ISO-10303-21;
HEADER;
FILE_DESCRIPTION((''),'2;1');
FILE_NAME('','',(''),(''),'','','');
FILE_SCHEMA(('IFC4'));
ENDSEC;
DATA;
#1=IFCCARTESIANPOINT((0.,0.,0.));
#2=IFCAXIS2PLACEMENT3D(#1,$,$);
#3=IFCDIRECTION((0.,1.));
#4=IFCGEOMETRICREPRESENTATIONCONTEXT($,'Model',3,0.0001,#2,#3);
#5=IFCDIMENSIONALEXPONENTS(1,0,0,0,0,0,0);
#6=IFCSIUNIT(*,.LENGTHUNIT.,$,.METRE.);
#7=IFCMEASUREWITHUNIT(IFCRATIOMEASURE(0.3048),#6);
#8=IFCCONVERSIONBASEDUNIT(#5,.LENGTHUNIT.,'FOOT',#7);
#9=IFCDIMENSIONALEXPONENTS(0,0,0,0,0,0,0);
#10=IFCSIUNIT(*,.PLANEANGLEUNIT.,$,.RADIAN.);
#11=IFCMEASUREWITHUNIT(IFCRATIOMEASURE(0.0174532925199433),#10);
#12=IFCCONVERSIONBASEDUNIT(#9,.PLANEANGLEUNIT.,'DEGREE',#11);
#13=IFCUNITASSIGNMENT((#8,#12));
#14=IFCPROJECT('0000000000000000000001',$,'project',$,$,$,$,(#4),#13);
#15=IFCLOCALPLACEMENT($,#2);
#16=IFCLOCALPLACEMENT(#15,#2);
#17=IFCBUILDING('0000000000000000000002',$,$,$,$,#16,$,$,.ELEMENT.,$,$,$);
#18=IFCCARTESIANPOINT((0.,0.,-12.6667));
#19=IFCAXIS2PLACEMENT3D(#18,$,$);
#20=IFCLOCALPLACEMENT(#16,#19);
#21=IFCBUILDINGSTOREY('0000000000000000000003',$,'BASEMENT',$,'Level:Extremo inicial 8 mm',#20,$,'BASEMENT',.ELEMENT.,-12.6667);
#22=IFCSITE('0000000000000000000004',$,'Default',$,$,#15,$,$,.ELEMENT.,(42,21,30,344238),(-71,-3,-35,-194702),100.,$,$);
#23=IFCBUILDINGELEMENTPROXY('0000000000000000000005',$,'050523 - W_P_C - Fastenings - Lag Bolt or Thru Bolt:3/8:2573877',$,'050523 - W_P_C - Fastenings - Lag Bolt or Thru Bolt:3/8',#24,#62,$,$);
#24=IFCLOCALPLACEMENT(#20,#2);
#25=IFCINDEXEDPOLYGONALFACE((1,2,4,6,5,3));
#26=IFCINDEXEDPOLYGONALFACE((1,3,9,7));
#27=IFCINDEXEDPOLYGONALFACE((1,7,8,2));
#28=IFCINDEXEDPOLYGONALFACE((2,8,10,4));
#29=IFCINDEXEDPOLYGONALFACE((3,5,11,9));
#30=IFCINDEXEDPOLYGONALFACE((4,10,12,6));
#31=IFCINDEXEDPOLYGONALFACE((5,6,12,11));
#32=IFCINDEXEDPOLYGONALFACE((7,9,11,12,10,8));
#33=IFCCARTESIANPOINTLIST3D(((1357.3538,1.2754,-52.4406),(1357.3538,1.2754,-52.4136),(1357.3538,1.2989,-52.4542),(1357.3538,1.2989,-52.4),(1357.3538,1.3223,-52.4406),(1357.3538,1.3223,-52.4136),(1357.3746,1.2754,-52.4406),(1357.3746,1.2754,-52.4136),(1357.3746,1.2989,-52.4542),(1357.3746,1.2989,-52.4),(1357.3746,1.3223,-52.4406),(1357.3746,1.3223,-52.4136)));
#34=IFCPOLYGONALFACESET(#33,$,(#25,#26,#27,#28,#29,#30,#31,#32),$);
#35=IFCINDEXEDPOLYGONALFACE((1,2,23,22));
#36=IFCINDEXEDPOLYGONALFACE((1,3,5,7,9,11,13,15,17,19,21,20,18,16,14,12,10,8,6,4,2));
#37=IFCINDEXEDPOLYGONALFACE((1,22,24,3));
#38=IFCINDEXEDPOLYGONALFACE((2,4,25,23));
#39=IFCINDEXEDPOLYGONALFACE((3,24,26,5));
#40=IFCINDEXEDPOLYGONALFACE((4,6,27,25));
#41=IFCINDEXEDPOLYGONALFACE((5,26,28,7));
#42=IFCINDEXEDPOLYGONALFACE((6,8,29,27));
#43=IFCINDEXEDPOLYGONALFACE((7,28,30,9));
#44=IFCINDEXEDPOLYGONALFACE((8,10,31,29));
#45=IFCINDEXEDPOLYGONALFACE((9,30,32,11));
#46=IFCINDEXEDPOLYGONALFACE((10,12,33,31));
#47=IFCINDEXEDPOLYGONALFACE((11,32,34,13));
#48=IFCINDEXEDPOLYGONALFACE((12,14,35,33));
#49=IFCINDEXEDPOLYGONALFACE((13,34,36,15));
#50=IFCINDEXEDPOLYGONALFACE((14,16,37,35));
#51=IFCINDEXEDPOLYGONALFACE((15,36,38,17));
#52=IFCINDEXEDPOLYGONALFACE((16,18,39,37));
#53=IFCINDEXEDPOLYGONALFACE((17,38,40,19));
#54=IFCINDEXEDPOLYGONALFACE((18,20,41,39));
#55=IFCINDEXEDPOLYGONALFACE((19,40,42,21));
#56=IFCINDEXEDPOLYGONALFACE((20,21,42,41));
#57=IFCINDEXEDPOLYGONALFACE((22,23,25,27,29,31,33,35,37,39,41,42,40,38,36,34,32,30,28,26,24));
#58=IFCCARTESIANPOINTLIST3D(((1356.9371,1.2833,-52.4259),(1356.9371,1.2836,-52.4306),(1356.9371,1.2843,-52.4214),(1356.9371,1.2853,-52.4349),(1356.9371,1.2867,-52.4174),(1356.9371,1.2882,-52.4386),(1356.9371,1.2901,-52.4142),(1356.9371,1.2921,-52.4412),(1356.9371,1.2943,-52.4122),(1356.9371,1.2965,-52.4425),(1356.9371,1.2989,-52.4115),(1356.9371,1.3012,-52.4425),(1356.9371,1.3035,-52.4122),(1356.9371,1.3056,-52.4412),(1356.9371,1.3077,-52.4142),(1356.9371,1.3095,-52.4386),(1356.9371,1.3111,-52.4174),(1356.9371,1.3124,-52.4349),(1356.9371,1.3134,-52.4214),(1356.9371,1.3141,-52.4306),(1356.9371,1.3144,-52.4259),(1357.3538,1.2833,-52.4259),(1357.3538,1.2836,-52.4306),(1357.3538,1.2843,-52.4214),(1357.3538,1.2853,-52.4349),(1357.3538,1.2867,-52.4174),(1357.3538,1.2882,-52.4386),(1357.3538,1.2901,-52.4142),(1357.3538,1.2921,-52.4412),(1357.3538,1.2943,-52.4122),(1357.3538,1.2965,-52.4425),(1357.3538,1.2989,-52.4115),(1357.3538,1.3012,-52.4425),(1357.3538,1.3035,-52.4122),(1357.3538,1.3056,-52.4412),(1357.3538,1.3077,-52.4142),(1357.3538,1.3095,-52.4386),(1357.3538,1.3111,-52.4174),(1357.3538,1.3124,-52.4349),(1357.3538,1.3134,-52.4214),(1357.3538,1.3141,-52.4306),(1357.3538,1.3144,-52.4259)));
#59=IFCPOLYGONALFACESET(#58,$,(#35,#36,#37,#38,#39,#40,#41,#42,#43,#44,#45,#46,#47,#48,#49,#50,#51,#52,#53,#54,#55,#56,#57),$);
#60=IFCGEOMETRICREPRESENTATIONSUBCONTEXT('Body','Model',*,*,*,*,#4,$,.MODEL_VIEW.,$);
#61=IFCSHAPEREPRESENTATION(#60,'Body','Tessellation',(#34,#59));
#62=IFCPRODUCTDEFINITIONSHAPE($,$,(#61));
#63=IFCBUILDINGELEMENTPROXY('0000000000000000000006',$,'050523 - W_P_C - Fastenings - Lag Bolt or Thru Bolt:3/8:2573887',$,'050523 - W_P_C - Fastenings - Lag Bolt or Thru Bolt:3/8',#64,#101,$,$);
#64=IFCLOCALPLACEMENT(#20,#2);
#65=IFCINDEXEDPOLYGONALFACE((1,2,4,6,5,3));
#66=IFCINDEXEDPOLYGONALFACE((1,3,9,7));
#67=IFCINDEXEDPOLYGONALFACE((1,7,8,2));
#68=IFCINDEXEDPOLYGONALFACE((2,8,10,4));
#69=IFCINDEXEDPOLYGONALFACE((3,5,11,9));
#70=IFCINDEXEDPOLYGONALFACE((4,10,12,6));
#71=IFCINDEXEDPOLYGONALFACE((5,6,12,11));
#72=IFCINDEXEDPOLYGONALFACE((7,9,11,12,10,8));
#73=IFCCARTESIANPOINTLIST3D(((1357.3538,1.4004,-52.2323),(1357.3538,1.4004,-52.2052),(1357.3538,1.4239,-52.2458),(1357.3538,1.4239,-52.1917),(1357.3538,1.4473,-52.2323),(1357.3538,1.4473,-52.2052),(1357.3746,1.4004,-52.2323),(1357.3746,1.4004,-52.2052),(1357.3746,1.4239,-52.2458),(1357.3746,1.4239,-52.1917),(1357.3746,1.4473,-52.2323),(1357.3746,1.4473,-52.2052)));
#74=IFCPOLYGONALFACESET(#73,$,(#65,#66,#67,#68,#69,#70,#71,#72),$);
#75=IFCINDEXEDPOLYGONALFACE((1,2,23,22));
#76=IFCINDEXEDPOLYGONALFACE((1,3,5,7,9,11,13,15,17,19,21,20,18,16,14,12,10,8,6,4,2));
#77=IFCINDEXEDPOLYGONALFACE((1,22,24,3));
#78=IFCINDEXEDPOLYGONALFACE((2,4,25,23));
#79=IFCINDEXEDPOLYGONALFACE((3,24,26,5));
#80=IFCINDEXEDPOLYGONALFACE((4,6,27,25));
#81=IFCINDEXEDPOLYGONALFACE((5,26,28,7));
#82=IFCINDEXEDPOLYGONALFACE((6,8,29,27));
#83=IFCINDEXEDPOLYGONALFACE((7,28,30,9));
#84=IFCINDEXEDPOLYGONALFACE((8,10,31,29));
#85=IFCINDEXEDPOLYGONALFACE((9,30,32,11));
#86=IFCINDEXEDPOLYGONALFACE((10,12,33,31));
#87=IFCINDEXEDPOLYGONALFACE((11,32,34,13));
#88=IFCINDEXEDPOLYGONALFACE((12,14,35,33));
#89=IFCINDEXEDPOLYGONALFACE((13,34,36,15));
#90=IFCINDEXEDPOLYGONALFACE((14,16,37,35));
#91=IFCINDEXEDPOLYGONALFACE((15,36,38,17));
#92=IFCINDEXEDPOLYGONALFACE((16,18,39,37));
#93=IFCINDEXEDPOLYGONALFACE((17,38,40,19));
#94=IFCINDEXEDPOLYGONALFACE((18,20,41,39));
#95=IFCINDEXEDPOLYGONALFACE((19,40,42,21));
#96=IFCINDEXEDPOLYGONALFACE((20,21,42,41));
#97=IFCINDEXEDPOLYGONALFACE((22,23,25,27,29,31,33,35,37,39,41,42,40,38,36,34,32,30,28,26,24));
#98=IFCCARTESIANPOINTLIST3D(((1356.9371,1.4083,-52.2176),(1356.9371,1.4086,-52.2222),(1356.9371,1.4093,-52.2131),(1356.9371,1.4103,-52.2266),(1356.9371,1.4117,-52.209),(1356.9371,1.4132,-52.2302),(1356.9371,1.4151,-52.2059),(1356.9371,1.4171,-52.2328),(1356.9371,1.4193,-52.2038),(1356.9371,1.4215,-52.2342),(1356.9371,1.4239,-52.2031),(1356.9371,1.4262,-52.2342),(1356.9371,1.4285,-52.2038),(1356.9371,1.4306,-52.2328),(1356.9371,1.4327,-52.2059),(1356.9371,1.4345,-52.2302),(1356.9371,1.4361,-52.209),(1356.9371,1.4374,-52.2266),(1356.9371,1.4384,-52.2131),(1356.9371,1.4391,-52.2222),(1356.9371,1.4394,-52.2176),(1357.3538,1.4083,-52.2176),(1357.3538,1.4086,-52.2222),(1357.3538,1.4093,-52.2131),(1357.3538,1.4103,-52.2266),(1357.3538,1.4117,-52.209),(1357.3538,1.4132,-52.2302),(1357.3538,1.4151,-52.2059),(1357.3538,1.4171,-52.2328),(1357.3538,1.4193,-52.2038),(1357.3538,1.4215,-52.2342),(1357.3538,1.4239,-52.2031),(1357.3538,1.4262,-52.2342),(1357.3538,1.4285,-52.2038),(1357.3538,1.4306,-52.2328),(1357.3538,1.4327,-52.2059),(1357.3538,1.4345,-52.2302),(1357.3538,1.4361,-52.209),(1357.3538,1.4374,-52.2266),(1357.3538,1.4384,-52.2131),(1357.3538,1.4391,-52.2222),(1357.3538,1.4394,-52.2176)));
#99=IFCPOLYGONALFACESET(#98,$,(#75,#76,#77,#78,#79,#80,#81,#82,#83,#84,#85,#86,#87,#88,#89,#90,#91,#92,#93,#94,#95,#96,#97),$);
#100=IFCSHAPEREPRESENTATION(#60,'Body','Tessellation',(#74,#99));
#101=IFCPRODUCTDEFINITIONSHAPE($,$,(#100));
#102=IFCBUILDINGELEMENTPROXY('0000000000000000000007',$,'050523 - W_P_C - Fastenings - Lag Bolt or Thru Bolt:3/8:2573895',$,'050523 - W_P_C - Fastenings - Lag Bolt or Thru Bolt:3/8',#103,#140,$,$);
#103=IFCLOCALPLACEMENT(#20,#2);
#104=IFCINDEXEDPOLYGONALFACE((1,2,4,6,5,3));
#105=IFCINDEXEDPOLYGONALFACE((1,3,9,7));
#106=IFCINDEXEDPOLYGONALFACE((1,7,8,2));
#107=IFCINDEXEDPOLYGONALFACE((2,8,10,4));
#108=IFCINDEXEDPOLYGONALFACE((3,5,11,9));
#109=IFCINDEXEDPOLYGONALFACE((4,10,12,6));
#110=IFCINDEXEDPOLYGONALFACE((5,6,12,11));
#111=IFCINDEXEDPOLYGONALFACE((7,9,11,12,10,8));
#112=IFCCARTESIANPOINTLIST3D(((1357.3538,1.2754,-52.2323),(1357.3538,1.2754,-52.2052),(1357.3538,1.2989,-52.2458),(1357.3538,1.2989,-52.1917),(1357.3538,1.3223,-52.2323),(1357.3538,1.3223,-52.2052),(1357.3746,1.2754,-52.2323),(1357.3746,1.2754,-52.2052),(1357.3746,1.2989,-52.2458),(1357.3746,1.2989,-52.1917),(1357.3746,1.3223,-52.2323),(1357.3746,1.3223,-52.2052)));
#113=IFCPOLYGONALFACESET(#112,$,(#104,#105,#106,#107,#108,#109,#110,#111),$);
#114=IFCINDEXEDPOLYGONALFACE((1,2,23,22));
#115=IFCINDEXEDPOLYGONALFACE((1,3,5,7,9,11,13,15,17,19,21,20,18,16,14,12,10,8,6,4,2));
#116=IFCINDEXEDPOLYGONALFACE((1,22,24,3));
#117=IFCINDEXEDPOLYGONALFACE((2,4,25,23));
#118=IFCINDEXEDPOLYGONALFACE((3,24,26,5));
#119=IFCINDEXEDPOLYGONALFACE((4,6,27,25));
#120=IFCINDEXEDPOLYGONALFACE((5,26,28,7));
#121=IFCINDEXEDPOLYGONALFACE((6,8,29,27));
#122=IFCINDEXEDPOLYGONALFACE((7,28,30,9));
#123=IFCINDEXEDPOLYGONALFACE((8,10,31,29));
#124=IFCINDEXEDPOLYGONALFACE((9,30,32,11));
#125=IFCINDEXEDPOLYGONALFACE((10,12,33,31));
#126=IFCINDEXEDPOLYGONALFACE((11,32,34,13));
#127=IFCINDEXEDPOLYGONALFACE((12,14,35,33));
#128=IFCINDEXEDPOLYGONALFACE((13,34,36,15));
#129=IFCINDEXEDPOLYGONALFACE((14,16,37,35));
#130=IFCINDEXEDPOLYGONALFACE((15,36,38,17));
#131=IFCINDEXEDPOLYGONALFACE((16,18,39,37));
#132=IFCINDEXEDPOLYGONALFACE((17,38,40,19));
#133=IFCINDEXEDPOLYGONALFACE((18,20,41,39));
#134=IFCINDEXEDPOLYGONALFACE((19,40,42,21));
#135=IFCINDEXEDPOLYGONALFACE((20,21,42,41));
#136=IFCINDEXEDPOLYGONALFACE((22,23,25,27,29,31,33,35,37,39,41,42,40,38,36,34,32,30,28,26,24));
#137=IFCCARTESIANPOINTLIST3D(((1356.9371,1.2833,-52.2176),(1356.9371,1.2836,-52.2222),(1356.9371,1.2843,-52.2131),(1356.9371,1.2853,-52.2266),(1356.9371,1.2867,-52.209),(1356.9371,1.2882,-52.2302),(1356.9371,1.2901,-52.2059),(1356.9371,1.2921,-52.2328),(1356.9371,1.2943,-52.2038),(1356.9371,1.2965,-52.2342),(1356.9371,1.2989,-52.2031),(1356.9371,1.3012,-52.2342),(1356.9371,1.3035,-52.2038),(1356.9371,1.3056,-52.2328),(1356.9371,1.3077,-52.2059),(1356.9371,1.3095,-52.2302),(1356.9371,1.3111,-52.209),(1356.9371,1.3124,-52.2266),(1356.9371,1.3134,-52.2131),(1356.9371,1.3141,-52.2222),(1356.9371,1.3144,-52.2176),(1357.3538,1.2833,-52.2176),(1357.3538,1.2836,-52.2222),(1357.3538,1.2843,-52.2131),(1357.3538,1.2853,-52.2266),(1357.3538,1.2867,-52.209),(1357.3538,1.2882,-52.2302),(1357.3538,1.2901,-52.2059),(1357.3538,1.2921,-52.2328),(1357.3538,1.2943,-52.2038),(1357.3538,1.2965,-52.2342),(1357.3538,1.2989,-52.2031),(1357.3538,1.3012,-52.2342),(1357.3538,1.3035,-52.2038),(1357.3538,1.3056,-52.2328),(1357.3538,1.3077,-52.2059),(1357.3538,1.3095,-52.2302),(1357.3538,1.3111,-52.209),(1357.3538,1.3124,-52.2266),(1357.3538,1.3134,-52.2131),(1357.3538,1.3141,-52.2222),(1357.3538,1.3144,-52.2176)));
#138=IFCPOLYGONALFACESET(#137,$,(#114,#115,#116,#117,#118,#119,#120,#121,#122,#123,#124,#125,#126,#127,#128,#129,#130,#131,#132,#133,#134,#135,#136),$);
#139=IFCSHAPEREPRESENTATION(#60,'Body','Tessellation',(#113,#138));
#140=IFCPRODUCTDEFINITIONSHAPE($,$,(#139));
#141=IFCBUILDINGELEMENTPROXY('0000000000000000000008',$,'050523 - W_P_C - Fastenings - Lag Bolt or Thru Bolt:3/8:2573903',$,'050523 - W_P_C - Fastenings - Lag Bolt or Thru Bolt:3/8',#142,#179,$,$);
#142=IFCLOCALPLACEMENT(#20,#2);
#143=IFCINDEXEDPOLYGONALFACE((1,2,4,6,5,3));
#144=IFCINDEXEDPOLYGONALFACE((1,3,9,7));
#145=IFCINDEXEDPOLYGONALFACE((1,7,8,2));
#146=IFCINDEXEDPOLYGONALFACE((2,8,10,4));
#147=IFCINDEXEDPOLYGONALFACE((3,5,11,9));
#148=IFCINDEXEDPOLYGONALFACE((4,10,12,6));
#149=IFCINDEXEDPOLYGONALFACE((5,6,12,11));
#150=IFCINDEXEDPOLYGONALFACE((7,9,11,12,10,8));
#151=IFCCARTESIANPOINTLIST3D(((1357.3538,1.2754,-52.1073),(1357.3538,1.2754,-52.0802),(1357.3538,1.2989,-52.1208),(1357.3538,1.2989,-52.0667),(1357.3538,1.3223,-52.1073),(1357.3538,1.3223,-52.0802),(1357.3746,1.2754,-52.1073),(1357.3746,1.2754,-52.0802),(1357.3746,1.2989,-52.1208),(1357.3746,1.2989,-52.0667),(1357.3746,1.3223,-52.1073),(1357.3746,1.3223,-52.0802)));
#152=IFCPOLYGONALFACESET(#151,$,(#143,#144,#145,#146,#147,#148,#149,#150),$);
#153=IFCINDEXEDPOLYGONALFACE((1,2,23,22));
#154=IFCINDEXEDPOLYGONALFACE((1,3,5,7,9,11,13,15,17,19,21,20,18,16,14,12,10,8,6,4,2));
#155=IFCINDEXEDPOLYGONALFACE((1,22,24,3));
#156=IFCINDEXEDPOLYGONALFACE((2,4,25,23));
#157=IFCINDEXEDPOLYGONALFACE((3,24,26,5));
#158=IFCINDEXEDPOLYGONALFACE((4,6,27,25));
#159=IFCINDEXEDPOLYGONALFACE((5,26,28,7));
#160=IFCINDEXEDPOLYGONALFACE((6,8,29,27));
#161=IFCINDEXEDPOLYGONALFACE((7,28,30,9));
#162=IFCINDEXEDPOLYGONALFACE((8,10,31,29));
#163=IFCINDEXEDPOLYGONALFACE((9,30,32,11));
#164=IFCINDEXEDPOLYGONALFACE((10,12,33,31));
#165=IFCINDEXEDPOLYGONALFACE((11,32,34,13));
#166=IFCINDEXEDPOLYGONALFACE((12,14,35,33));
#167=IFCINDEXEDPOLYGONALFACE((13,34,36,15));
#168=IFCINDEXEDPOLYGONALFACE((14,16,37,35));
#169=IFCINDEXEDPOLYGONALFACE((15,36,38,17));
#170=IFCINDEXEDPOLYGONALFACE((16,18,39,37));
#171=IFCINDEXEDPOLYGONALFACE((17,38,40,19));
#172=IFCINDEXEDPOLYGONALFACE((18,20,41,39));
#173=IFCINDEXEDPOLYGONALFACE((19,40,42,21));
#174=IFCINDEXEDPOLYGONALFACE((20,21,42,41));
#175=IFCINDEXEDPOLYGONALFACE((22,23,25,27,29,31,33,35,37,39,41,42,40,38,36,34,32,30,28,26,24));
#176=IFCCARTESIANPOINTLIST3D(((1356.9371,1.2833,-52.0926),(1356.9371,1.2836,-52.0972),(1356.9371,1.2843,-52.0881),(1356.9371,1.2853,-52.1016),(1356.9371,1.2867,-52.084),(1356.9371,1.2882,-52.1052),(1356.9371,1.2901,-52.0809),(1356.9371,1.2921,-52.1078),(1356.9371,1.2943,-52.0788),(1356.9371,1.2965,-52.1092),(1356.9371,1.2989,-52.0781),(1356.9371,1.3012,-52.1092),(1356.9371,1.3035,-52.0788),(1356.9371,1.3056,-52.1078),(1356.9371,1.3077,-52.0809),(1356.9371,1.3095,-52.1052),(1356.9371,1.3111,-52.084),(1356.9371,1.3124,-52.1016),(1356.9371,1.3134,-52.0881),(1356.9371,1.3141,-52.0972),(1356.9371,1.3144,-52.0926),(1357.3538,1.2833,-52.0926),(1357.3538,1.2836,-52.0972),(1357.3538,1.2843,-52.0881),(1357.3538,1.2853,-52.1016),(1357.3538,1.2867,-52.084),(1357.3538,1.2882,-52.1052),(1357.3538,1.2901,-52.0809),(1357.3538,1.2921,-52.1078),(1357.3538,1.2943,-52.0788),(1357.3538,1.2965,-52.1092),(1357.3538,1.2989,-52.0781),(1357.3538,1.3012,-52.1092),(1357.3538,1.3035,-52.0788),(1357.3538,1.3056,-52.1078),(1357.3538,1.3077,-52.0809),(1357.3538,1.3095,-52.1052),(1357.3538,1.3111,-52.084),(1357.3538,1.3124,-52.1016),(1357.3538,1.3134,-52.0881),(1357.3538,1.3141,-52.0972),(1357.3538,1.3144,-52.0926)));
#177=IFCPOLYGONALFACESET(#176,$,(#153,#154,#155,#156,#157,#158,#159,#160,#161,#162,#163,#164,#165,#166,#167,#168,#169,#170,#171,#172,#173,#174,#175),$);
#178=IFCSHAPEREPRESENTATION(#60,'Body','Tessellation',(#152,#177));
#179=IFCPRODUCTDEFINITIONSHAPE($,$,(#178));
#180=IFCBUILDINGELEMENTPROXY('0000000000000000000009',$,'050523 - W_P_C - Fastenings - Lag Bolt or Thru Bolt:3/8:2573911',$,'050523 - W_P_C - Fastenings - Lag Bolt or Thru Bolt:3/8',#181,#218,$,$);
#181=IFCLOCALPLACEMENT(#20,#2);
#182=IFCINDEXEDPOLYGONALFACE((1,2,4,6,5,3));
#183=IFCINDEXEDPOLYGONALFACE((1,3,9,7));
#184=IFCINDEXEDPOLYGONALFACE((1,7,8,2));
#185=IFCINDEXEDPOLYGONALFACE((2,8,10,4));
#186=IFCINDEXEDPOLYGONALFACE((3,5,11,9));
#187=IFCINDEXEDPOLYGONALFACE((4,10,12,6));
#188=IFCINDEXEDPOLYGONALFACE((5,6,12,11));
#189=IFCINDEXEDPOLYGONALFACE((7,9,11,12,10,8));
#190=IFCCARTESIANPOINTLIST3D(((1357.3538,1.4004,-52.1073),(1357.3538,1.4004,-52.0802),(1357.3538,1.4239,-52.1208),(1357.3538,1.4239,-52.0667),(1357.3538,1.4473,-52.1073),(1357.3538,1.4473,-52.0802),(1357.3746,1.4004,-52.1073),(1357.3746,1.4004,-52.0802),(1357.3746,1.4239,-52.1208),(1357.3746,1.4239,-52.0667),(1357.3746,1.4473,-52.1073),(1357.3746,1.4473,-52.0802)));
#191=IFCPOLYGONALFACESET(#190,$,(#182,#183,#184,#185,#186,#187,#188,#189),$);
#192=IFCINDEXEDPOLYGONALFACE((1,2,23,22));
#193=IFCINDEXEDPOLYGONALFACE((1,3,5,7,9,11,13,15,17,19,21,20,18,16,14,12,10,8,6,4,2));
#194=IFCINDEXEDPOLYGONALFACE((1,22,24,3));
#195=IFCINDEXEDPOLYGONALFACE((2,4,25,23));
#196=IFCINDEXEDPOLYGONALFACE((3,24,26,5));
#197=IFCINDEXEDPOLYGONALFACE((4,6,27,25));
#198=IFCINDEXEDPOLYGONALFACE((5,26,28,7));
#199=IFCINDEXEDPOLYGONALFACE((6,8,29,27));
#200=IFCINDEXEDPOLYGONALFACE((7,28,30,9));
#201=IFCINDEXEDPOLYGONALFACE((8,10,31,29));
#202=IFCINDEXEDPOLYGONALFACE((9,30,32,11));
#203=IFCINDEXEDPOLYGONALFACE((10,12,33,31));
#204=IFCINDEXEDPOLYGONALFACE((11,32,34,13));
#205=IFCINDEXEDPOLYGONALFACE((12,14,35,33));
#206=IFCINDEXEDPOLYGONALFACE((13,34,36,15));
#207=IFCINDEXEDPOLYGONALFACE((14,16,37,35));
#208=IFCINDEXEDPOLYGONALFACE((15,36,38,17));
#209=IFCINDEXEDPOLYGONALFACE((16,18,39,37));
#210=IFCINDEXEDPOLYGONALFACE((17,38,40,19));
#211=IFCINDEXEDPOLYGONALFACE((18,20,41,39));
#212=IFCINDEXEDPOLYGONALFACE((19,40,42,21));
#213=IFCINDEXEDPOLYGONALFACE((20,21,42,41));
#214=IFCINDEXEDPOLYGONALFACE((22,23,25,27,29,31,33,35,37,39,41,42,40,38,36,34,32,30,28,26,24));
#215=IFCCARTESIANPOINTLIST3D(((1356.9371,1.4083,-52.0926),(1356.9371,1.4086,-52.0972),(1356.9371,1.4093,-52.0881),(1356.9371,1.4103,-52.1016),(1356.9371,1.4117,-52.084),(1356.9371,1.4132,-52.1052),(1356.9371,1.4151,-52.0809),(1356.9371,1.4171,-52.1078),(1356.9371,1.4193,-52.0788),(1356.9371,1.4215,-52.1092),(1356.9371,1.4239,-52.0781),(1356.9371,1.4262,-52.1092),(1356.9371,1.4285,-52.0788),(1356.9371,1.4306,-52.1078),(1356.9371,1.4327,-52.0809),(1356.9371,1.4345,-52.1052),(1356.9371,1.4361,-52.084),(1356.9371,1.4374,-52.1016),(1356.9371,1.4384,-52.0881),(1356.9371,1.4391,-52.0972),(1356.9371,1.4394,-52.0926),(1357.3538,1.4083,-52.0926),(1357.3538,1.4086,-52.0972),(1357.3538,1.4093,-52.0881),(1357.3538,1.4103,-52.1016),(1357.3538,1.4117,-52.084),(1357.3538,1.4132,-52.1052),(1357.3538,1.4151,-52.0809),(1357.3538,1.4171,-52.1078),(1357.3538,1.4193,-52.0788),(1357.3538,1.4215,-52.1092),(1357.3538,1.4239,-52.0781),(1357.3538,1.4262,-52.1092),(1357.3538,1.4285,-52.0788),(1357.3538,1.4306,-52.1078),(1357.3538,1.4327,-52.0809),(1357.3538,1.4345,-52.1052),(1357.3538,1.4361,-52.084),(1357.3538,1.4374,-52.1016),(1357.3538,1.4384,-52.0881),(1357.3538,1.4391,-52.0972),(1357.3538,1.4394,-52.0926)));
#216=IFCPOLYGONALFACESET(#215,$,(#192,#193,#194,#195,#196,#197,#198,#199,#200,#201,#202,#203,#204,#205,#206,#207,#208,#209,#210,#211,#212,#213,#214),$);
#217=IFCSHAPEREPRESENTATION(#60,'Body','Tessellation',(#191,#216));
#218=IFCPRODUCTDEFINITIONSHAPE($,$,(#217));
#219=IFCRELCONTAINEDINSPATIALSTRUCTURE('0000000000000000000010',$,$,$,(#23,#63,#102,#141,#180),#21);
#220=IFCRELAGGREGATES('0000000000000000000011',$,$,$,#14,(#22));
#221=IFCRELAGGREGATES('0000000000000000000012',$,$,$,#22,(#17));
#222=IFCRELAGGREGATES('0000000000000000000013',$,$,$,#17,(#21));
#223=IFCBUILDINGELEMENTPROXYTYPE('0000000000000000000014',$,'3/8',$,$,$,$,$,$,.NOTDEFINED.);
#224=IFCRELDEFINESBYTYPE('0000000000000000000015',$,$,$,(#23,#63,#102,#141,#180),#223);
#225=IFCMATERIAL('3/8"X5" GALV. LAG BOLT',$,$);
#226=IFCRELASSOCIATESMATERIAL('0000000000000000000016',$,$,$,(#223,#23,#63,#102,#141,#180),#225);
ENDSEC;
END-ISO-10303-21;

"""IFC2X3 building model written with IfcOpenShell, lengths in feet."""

from ifc_helpers import new_model, entity, si_unit, converted_unit, direction, frame, frame_2d, origin, place, context, subcontext, project, spatial, polyline, circle, outline, extrude, source, transform, mapped, material, type_object, type_shapes, element, save


model = new_model("IFC2X3")

# Units and contexts
model_context = context("Model", 3, precision=0.0001, world=origin(), true_north=direction((0.0, 1.0)))
body_context = subcontext(model_context, "Body", "Model", "MODEL_VIEW")
ifc_project = project(units=[converted_unit("LENGTHUNIT", "FOOT", entity("IfcRatioMeasure", 0.3048), si_unit("LENGTHUNIT", "METRE"), dimensions=[1, 0, 0, 0, 0, 0, 0]), converted_unit("PLANEANGLEUNIT", "DEGREE", entity("IfcRatioMeasure", 0.0174532925199433), si_unit("PLANEANGLEUNIT", "RADIAN"), dimensions=[0, 0, 0, 0, 0, 0, 0])], contexts=[model_context])

# Site, building, storey
site_placement = place(None, origin())
site = spatial("IfcSite", under=ifc_project, at=site_placement, Name="Default", CompositionType="ELEMENT", RefLatitude=(42, 21, 30, 344238), RefLongitude=(-71, -3, -35, -194702), RefElevation=100.0)
building_placement = place(site_placement, origin())
building = spatial("IfcBuilding", under=site, at=building_placement, CompositionType="ELEMENT")
storey_placement = place(building_placement, frame((0.0, 0.0, -12.6667)))
storey = spatial("IfcBuildingStorey", under=building, at=storey_placement, Name="BASEMENT", ObjectType="Level:Extremo inicial 8 mm", LongName="BASEMENT", CompositionType="ELEMENT", Elevation=-12.6667)

# Building element proxies
ifc_material_1 = material(Name="3/8\"X5\" GALV. LAG BOLT")
building_element_proxy_type_1 = type_object("IfcBuildingElementProxyType", Name="3/8", PredefinedType="NOTDEFINED", material=ifc_material_1)
shared_shape_1 = source(origin(), body_context, "Body", "SweptSolid", [
    extrude(outline(polyline([(-0.0135, -0.0234), (0.0135, -0.0234), (0.0271, 0.0), (0.0135, 0.0234), (-0.0135, 0.0234), (-0.0271, 0.0), (-0.0135, -0.0234)])), frame((0.0, 0.0, 0.0), z_axis=(0.0, 0.0, 1.0), x_axis=(0.0, -1.0, 0.0)), (0.0, 0.0, 1.0), 0.0208),
    extrude(circle(Radius=0.0156, at=frame_2d((0.0, 0.0), x_axis=(1.0, 0.0))), frame((0.0, 0.0, -0.4167), z_axis=(0.0, 0.0, 1.0), x_axis=(0.0, 1.0, 0.0)), (0.0, 0.0, 1.0), 0.4167),
])
type_shapes(building_element_proxy_type_1, [shared_shape_1])
for number, where, z_axis, x_axis, name in (
    (1, (1357.3538, 1.2989, -52.4271), (1.0, 0.0, 0.0), (0.0, 1.0, 0.0), "050523 - W_P_C - Fastenings - Lag Bolt or Thru Bolt:3/8:2573877"),
    (2, (1357.3538, 1.4239, -52.2188), (1.0, 0.0, 0.0), (0.0, 1.0, 0.0), "050523 - W_P_C - Fastenings - Lag Bolt or Thru Bolt:3/8:2573887"),
    (3, (1357.3538, 1.2989, -52.2188), (1.0, 0.0, 0.0), (0.0, 1.0, 0.0), "050523 - W_P_C - Fastenings - Lag Bolt or Thru Bolt:3/8:2573895"),
    (4, (1357.3538, 1.2989, -52.0938), (1.0, 0.0, 0.0), (0.0, 1.0, 0.0), "050523 - W_P_C - Fastenings - Lag Bolt or Thru Bolt:3/8:2573903"),
    (5, (1357.3538, 1.4239, -52.0938), (1.0, 0.0, 0.0), (0.0, 1.0, 0.0), "050523 - W_P_C - Fastenings - Lag Bolt or Thru Bolt:3/8:2573911"),
):
    element("IfcBuildingElementProxy", number, at=place(storey_placement, frame(where, z_axis=z_axis, x_axis=x_axis)), inside=storey, type_object=building_element_proxy_type_1, material=ifc_material_1, Name=name, ObjectType="050523 - W_P_C - Fastenings - Lag Bolt or Thru Bolt:3/8", context=body_context, shape_type="MappedRepresentation", body=[
        mapped(shared_shape_1, transform((0.0, 0.0, 0.0), scale=1.0)),
    ])

save(model, "model.ifc")
